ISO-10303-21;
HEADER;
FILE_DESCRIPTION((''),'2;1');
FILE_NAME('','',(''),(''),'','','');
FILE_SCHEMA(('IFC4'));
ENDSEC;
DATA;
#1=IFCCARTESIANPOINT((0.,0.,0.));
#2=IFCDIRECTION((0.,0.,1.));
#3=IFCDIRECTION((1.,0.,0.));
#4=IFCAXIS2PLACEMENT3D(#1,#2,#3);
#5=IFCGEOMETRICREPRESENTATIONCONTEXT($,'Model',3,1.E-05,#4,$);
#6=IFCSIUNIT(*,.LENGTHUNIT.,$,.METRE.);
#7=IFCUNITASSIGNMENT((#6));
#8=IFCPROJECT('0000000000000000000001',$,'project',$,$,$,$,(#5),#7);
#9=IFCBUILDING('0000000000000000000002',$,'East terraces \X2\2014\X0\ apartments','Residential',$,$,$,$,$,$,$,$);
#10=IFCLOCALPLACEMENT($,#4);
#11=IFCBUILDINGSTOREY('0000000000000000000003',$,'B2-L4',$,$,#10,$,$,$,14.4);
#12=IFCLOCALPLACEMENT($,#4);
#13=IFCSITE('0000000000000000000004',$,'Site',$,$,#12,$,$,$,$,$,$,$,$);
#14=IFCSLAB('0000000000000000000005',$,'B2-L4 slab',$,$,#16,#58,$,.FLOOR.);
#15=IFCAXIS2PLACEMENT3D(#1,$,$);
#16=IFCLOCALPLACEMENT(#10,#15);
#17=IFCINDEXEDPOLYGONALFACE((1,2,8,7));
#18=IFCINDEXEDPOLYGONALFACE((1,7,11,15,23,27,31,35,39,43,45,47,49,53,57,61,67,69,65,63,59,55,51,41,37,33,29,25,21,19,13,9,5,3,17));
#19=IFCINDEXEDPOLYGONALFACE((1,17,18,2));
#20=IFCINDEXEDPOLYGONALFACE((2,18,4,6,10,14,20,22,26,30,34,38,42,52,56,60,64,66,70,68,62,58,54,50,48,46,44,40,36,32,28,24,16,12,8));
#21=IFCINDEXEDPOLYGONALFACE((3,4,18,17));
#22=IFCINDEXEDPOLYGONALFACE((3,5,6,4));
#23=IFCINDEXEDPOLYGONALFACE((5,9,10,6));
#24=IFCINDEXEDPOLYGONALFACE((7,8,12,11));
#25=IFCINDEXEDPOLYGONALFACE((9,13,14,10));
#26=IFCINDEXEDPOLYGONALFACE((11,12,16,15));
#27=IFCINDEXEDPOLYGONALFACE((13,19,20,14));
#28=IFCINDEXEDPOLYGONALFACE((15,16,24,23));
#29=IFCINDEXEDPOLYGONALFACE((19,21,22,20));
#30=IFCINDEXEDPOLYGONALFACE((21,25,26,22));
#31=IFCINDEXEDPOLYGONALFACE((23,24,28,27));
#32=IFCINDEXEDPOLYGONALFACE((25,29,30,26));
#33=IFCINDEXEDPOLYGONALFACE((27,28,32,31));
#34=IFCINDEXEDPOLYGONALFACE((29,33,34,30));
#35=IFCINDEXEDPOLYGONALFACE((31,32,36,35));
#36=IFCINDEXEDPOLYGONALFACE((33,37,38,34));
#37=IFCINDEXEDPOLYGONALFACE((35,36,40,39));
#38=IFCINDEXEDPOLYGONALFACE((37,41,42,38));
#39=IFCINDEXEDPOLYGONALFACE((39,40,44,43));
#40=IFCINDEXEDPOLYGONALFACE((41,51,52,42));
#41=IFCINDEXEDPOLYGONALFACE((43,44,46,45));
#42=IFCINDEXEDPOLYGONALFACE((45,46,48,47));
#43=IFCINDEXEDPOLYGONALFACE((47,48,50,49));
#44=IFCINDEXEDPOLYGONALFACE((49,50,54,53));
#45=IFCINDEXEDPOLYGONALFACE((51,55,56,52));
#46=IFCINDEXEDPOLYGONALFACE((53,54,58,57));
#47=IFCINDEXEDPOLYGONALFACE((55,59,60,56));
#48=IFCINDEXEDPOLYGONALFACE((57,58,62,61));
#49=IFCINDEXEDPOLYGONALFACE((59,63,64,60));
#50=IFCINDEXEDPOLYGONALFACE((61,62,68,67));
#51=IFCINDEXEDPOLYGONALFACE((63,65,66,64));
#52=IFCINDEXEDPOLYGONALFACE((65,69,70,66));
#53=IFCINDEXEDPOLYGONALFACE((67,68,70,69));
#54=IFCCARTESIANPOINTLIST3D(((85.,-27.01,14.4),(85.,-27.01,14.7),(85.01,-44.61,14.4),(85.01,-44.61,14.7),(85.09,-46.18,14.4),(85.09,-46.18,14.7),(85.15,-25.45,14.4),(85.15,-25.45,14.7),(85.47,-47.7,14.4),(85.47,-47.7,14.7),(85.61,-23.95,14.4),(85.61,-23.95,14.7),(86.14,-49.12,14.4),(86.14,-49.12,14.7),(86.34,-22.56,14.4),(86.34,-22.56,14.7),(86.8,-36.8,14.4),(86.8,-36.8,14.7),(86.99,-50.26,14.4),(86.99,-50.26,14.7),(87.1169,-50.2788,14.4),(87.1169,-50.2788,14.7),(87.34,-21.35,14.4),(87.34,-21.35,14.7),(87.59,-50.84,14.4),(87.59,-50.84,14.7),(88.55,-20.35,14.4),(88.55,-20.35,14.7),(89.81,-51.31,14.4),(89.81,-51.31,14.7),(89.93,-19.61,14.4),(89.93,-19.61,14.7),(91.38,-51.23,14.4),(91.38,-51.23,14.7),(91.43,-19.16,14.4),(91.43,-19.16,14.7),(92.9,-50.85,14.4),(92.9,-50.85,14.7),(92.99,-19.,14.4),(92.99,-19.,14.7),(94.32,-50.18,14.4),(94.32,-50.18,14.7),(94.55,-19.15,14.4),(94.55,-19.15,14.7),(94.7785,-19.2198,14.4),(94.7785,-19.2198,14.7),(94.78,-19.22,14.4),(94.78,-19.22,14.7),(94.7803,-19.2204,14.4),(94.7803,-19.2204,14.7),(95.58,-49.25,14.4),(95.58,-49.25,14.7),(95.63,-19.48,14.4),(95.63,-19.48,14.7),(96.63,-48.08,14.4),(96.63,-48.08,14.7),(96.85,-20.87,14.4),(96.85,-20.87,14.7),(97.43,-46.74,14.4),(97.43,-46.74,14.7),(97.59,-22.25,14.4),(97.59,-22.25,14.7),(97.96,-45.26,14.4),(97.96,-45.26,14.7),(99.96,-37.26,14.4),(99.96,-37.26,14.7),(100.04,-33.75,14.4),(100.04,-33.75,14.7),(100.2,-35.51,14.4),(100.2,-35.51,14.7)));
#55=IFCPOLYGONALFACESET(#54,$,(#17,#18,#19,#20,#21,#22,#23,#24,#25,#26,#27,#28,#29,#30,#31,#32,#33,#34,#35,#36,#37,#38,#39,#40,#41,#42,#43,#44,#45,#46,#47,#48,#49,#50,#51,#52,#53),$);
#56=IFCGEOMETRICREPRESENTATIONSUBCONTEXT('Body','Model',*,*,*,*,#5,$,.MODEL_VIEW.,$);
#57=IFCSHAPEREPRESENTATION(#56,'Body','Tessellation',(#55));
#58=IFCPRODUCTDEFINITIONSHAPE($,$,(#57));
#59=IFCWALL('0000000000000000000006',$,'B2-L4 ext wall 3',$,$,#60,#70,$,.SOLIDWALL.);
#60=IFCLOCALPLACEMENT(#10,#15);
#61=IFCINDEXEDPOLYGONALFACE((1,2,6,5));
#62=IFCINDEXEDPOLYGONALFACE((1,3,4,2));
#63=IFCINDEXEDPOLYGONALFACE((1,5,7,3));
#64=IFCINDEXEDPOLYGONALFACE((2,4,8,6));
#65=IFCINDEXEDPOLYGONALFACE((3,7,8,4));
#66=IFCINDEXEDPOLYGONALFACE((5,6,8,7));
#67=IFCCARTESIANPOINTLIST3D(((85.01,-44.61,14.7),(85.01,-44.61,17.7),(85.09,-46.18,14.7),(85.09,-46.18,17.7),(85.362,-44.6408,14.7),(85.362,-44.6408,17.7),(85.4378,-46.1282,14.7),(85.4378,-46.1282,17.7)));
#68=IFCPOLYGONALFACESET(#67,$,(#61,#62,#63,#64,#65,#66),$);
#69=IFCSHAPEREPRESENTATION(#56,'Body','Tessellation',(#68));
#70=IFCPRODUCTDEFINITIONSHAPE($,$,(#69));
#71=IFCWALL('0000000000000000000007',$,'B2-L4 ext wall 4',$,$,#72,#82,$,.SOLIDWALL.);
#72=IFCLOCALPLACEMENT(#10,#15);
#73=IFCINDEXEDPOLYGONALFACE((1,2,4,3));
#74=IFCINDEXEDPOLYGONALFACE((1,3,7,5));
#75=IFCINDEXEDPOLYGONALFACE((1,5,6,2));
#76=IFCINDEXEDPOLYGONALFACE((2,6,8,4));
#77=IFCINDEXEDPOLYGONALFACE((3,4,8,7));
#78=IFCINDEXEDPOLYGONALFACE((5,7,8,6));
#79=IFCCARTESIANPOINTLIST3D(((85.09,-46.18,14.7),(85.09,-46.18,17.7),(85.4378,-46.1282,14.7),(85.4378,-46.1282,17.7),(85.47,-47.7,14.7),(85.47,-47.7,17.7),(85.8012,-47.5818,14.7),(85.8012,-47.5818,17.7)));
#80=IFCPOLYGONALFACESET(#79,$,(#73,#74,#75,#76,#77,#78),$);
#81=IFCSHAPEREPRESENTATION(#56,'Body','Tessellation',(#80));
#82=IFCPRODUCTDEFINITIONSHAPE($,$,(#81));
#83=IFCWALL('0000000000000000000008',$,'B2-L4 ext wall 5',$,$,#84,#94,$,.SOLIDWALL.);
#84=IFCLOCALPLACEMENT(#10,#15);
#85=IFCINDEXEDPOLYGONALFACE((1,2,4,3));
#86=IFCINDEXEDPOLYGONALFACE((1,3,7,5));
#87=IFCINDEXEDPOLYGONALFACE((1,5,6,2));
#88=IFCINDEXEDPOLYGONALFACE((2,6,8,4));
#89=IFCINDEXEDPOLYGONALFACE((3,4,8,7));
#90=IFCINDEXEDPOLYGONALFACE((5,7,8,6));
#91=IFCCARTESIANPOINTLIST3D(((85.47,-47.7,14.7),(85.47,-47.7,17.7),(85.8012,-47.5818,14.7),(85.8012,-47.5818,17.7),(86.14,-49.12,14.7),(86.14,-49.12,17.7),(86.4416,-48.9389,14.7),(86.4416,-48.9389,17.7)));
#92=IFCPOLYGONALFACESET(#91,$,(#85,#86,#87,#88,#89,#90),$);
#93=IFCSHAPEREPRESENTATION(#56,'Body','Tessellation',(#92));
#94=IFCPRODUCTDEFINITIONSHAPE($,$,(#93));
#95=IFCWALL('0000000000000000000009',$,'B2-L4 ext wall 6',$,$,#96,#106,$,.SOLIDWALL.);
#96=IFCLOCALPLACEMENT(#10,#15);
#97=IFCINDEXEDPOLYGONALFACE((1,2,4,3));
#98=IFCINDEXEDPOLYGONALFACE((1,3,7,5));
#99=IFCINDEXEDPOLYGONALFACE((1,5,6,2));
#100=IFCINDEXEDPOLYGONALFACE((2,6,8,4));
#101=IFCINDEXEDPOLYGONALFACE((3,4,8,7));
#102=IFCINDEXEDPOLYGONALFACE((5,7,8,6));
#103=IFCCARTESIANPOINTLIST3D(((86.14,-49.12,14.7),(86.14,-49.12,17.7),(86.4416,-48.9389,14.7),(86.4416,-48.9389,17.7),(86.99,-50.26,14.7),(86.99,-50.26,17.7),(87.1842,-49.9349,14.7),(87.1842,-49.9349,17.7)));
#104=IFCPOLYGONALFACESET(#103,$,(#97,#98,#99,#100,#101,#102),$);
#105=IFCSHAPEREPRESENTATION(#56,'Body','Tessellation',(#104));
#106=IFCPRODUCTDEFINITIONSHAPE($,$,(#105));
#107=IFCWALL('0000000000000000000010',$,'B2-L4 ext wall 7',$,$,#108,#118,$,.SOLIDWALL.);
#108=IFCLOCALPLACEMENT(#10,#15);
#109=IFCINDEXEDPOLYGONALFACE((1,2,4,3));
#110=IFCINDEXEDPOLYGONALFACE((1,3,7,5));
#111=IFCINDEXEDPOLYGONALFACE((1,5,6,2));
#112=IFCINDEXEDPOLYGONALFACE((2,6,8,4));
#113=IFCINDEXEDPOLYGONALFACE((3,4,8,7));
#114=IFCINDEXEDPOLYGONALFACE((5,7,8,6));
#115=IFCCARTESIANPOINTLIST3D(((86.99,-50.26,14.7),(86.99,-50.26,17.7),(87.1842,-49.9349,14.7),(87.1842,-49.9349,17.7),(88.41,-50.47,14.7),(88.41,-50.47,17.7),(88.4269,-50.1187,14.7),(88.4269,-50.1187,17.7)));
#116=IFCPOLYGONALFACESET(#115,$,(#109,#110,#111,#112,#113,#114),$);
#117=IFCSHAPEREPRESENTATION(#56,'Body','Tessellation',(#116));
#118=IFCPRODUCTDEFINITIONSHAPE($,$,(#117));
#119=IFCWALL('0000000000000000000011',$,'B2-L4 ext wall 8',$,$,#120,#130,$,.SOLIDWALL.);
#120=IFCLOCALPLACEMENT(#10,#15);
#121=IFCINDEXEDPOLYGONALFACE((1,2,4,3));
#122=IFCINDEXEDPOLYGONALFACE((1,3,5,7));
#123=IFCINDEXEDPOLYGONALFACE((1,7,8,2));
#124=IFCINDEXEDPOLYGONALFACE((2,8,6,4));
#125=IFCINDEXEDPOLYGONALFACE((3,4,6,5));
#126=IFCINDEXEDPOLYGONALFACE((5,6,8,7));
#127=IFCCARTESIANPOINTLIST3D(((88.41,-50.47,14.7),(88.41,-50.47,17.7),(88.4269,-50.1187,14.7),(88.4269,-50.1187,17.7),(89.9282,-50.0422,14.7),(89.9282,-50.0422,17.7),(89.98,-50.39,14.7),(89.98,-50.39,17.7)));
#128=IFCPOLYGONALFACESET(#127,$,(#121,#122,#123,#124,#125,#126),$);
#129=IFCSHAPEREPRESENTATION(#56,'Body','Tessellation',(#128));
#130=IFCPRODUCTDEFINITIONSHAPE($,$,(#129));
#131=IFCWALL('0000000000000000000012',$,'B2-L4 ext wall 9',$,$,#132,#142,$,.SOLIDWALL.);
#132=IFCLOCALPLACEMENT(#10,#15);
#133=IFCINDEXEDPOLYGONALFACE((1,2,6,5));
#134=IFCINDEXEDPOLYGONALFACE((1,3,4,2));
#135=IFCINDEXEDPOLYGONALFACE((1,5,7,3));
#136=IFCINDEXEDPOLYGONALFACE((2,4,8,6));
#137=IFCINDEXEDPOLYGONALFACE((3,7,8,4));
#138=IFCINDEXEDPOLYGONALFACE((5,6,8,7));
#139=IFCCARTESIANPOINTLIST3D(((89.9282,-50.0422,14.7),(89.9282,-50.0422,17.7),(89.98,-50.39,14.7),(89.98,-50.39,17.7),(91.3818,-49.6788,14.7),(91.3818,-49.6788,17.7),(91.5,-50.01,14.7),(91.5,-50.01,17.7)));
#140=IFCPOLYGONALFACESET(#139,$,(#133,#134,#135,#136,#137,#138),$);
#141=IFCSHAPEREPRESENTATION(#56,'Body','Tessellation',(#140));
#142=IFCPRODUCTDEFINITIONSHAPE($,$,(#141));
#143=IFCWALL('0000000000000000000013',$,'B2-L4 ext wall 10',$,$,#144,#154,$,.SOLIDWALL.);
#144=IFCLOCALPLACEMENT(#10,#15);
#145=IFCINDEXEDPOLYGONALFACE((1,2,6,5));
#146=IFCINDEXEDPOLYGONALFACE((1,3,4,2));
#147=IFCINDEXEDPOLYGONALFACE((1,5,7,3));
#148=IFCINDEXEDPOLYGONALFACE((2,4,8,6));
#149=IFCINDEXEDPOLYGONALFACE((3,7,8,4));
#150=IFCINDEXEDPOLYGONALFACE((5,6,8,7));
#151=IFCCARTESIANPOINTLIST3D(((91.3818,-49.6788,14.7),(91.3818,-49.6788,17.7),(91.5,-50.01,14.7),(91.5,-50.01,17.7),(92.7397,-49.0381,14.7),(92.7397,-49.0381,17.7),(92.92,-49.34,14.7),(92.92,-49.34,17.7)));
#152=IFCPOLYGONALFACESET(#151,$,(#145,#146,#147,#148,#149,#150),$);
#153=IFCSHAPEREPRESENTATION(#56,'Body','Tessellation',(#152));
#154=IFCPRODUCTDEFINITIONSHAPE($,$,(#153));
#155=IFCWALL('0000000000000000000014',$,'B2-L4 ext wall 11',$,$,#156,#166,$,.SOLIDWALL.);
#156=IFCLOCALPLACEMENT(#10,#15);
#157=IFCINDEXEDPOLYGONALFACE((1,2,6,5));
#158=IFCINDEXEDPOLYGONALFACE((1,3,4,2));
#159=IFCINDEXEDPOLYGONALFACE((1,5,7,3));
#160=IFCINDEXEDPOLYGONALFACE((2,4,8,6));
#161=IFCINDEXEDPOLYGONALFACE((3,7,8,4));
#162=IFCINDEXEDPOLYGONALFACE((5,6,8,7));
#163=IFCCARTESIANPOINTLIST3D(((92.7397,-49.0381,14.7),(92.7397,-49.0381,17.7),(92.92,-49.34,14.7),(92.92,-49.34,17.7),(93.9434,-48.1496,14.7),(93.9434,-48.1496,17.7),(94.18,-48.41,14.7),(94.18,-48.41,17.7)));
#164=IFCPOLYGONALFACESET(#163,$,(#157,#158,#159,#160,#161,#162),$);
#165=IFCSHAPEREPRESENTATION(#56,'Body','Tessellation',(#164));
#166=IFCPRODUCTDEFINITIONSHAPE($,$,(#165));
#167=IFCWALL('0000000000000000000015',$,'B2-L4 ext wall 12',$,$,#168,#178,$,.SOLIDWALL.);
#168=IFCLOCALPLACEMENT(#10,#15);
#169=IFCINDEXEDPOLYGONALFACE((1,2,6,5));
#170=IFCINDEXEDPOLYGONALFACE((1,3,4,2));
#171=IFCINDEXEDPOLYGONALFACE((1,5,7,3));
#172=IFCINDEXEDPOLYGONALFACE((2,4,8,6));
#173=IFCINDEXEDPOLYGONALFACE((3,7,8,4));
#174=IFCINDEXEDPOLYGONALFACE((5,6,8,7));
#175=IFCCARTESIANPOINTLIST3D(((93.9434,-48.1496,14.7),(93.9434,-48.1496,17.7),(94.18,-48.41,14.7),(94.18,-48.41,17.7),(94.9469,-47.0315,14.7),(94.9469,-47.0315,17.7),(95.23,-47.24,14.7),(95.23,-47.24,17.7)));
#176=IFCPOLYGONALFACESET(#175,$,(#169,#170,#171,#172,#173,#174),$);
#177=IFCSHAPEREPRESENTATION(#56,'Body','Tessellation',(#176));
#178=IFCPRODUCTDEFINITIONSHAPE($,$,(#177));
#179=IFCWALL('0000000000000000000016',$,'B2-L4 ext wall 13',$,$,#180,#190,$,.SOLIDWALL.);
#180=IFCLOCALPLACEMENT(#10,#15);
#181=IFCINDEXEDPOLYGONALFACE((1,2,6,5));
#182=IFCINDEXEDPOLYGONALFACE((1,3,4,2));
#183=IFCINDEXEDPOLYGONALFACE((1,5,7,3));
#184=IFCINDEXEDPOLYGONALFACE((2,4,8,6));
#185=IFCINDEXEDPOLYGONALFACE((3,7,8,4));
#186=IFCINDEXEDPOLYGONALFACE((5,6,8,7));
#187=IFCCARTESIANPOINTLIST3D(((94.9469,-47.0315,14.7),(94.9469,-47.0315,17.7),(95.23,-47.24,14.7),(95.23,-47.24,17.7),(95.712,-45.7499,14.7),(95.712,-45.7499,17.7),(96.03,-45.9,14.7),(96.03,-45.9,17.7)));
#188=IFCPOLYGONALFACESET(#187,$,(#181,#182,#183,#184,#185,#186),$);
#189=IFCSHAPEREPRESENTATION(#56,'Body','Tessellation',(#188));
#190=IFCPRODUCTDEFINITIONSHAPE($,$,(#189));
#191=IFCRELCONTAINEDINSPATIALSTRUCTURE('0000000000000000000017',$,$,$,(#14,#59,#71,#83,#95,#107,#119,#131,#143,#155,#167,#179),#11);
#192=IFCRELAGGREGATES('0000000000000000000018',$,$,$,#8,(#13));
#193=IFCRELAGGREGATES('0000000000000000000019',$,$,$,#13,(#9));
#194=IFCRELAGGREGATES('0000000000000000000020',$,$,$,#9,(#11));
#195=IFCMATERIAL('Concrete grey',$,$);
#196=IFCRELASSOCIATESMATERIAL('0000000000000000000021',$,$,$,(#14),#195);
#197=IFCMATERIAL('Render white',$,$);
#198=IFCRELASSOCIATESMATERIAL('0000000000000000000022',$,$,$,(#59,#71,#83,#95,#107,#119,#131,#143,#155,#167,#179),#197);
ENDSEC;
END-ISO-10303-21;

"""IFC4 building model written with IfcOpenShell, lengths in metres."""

from ifc_helpers import new_model, si_unit, frame, origin_with_axes, place, context, subcontext, project, spatial, polyline, outline, extrude, material, element, save


model = new_model("IFC4")

# Units and contexts
model_context = context("Model", 3, precision=1e-05, world=origin_with_axes())
body_context = subcontext(model_context, "Body", "Model", "MODEL_VIEW")
ifc_project = project(units=[si_unit("LENGTHUNIT", "METRE")], contexts=[model_context])

# Site, building, storey
site_placement = place(None, origin_with_axes())
site = spatial("IfcSite", under=ifc_project, at=site_placement, Name="Site")
building = spatial("IfcBuilding", under=site, Name="East terraces — apartments", Description="Residential")
storey_placement = place(None, origin_with_axes())
storey = spatial("IfcBuildingStorey", under=building, at=storey_placement, Name="B2-L4", Elevation=14.4)

# Slab
ifc_material_1 = material(Name="Concrete grey")
slab_placement = place(storey_placement, origin_with_axes())
element("IfcSlab", 1, at=slab_placement, inside=storey, material=ifc_material_1, Name="B2-L4 slab", PredefinedType="FLOOR", context=body_context, shape_type="SweptSolid", body=[
    extrude(outline(polyline([(85.0, -27.01), (86.8, -36.8), (85.01, -44.61), (85.09, -46.18), (85.47, -47.7), (86.14, -49.12), (86.99, -50.26), (87.1169, -50.2788), (87.59, -50.84), (89.81, -51.31), (91.38, -51.23), (92.9, -50.85), (94.32, -50.18), (95.58, -49.25), (96.63, -48.08), (97.43, -46.74), (97.96, -45.26), (99.96, -37.26), (100.2, -35.51), (100.04, -33.75), (97.59, -22.25), (96.85, -20.87), (95.63, -19.48), (94.7803, -19.2204), (94.78, -19.22), (94.7785, -19.2198), (94.55, -19.15), (92.99, -19.0), (91.43, -19.16), (89.93, -19.61), (88.55, -20.35), (87.34, -21.35), (86.34, -22.56), (85.61, -23.95), (85.15, -25.45), (85.0, -27.01)])), frame((0.0, 0.0, 14.4), z_axis=(0.0, 0.0, 1.0), x_axis=(1.0, 0.0, 0.0)), (0.0, 0.0, 1.0), 0.3),
])

# Shared definitions
ifc_material_2 = material(Name="Render white")

# Walls
wall_1_placement = place(storey_placement, origin_with_axes())
element("IfcWall", 2, at=wall_1_placement, inside=storey, material=ifc_material_2, Name="B2-L4 ext wall 3", PredefinedType="SOLIDWALL", context=body_context, shape_type="SweptSolid", body=[
    extrude(outline(polyline([(85.01, -44.61), (85.09, -46.18), (85.4378, -46.1282), (85.362, -44.6408), (85.01, -44.61)])), frame((0.0, 0.0, 14.7), z_axis=(0.0, 0.0, 1.0), x_axis=(1.0, 0.0, 0.0)), (0.0, 0.0, 1.0), 3.0),
])
wall_2_placement = place(storey_placement, origin_with_axes())
element("IfcWall", 3, at=wall_2_placement, inside=storey, material=ifc_material_2, Name="B2-L4 ext wall 4", PredefinedType="SOLIDWALL", context=body_context, shape_type="SweptSolid", body=[
    extrude(outline(polyline([(85.09, -46.18), (85.47, -47.7), (85.8012, -47.5818), (85.4378, -46.1282), (85.09, -46.18)])), frame((0.0, 0.0, 14.7), z_axis=(0.0, 0.0, 1.0), x_axis=(1.0, 0.0, 0.0)), (0.0, 0.0, 1.0), 3.0),
])
wall_3_placement = place(storey_placement, origin_with_axes())
element("IfcWall", 4, at=wall_3_placement, inside=storey, material=ifc_material_2, Name="B2-L4 ext wall 5", PredefinedType="SOLIDWALL", context=body_context, shape_type="SweptSolid", body=[
    extrude(outline(polyline([(85.47, -47.7), (86.14, -49.12), (86.4416, -48.9389), (85.8012, -47.5818), (85.47, -47.7)])), frame((0.0, 0.0, 14.7), z_axis=(0.0, 0.0, 1.0), x_axis=(1.0, 0.0, 0.0)), (0.0, 0.0, 1.0), 3.0),
])
wall_4_placement = place(storey_placement, origin_with_axes())
element("IfcWall", 5, at=wall_4_placement, inside=storey, material=ifc_material_2, Name="B2-L4 ext wall 6", PredefinedType="SOLIDWALL", context=body_context, shape_type="SweptSolid", body=[
    extrude(outline(polyline([(86.14, -49.12), (86.99, -50.26), (87.1842, -49.9349), (86.4416, -48.9389), (86.14, -49.12)])), frame((0.0, 0.0, 14.7), z_axis=(0.0, 0.0, 1.0), x_axis=(1.0, 0.0, 0.0)), (0.0, 0.0, 1.0), 3.0),
])
wall_5_placement = place(storey_placement, origin_with_axes())
element("IfcWall", 6, at=wall_5_placement, inside=storey, material=ifc_material_2, Name="B2-L4 ext wall 7", PredefinedType="SOLIDWALL", context=body_context, shape_type="SweptSolid", body=[
    extrude(outline(polyline([(86.99, -50.26), (88.41, -50.47), (88.4269, -50.1187), (87.1842, -49.9349), (86.99, -50.26)])), frame((0.0, 0.0, 14.7), z_axis=(0.0, 0.0, 1.0), x_axis=(1.0, 0.0, 0.0)), (0.0, 0.0, 1.0), 3.0),
])
wall_6_placement = place(storey_placement, origin_with_axes())
element("IfcWall", 7, at=wall_6_placement, inside=storey, material=ifc_material_2, Name="B2-L4 ext wall 8", PredefinedType="SOLIDWALL", context=body_context, shape_type="SweptSolid", body=[
    extrude(outline(polyline([(88.41, -50.47), (89.98, -50.39), (89.9282, -50.0422), (88.4269, -50.1187), (88.41, -50.47)])), frame((0.0, 0.0, 14.7), z_axis=(0.0, 0.0, 1.0), x_axis=(1.0, 0.0, 0.0)), (0.0, 0.0, 1.0), 3.0),
])
wall_7_placement = place(storey_placement, origin_with_axes())
element("IfcWall", 8, at=wall_7_placement, inside=storey, material=ifc_material_2, Name="B2-L4 ext wall 9", PredefinedType="SOLIDWALL", context=body_context, shape_type="SweptSolid", body=[
    extrude(outline(polyline([(89.98, -50.39), (91.5, -50.01), (91.3818, -49.6788), (89.9282, -50.0422), (89.98, -50.39)])), frame((0.0, 0.0, 14.7), z_axis=(0.0, 0.0, 1.0), x_axis=(1.0, 0.0, 0.0)), (0.0, 0.0, 1.0), 3.0),
])
wall_8_placement = place(storey_placement, origin_with_axes())
element("IfcWall", 9, at=wall_8_placement, inside=storey, material=ifc_material_2, Name="B2-L4 ext wall 10", PredefinedType="SOLIDWALL", context=body_context, shape_type="SweptSolid", body=[
    extrude(outline(polyline([(91.5, -50.01), (92.92, -49.34), (92.7397, -49.0381), (91.3818, -49.6788), (91.5, -50.01)])), frame((0.0, 0.0, 14.7), z_axis=(0.0, 0.0, 1.0), x_axis=(1.0, 0.0, 0.0)), (0.0, 0.0, 1.0), 3.0),
])
wall_9_placement = place(storey_placement, origin_with_axes())
element("IfcWall", 10, at=wall_9_placement, inside=storey, material=ifc_material_2, Name="B2-L4 ext wall 11", PredefinedType="SOLIDWALL", context=body_context, shape_type="SweptSolid", body=[
    extrude(outline(polyline([(92.92, -49.34), (94.18, -48.41), (93.9434, -48.1496), (92.7397, -49.0381), (92.92, -49.34)])), frame((0.0, 0.0, 14.7), z_axis=(0.0, 0.0, 1.0), x_axis=(1.0, 0.0, 0.0)), (0.0, 0.0, 1.0), 3.0),
])
wall_10_placement = place(storey_placement, origin_with_axes())
element("IfcWall", 11, at=wall_10_placement, inside=storey, material=ifc_material_2, Name="B2-L4 ext wall 12", PredefinedType="SOLIDWALL", context=body_context, shape_type="SweptSolid", body=[
    extrude(outline(polyline([(94.18, -48.41), (95.23, -47.24), (94.9469, -47.0315), (93.9434, -48.1496), (94.18, -48.41)])), frame((0.0, 0.0, 14.7), z_axis=(0.0, 0.0, 1.0), x_axis=(1.0, 0.0, 0.0)), (0.0, 0.0, 1.0), 3.0),
])
wall_11_placement = place(storey_placement, origin_with_axes())
element("IfcWall", 12, at=wall_11_placement, inside=storey, material=ifc_material_2, Name="B2-L4 ext wall 13", PredefinedType="SOLIDWALL", context=body_context, shape_type="SweptSolid", body=[
    extrude(outline(polyline([(95.23, -47.24), (96.03, -45.9), (95.712, -45.7499), (94.9469, -47.0315), (95.23, -47.24)])), frame((0.0, 0.0, 14.7), z_axis=(0.0, 0.0, 1.0), x_axis=(1.0, 0.0, 0.0)), (0.0, 0.0, 1.0), 3.0),
])

save(model, "model.ifc")
